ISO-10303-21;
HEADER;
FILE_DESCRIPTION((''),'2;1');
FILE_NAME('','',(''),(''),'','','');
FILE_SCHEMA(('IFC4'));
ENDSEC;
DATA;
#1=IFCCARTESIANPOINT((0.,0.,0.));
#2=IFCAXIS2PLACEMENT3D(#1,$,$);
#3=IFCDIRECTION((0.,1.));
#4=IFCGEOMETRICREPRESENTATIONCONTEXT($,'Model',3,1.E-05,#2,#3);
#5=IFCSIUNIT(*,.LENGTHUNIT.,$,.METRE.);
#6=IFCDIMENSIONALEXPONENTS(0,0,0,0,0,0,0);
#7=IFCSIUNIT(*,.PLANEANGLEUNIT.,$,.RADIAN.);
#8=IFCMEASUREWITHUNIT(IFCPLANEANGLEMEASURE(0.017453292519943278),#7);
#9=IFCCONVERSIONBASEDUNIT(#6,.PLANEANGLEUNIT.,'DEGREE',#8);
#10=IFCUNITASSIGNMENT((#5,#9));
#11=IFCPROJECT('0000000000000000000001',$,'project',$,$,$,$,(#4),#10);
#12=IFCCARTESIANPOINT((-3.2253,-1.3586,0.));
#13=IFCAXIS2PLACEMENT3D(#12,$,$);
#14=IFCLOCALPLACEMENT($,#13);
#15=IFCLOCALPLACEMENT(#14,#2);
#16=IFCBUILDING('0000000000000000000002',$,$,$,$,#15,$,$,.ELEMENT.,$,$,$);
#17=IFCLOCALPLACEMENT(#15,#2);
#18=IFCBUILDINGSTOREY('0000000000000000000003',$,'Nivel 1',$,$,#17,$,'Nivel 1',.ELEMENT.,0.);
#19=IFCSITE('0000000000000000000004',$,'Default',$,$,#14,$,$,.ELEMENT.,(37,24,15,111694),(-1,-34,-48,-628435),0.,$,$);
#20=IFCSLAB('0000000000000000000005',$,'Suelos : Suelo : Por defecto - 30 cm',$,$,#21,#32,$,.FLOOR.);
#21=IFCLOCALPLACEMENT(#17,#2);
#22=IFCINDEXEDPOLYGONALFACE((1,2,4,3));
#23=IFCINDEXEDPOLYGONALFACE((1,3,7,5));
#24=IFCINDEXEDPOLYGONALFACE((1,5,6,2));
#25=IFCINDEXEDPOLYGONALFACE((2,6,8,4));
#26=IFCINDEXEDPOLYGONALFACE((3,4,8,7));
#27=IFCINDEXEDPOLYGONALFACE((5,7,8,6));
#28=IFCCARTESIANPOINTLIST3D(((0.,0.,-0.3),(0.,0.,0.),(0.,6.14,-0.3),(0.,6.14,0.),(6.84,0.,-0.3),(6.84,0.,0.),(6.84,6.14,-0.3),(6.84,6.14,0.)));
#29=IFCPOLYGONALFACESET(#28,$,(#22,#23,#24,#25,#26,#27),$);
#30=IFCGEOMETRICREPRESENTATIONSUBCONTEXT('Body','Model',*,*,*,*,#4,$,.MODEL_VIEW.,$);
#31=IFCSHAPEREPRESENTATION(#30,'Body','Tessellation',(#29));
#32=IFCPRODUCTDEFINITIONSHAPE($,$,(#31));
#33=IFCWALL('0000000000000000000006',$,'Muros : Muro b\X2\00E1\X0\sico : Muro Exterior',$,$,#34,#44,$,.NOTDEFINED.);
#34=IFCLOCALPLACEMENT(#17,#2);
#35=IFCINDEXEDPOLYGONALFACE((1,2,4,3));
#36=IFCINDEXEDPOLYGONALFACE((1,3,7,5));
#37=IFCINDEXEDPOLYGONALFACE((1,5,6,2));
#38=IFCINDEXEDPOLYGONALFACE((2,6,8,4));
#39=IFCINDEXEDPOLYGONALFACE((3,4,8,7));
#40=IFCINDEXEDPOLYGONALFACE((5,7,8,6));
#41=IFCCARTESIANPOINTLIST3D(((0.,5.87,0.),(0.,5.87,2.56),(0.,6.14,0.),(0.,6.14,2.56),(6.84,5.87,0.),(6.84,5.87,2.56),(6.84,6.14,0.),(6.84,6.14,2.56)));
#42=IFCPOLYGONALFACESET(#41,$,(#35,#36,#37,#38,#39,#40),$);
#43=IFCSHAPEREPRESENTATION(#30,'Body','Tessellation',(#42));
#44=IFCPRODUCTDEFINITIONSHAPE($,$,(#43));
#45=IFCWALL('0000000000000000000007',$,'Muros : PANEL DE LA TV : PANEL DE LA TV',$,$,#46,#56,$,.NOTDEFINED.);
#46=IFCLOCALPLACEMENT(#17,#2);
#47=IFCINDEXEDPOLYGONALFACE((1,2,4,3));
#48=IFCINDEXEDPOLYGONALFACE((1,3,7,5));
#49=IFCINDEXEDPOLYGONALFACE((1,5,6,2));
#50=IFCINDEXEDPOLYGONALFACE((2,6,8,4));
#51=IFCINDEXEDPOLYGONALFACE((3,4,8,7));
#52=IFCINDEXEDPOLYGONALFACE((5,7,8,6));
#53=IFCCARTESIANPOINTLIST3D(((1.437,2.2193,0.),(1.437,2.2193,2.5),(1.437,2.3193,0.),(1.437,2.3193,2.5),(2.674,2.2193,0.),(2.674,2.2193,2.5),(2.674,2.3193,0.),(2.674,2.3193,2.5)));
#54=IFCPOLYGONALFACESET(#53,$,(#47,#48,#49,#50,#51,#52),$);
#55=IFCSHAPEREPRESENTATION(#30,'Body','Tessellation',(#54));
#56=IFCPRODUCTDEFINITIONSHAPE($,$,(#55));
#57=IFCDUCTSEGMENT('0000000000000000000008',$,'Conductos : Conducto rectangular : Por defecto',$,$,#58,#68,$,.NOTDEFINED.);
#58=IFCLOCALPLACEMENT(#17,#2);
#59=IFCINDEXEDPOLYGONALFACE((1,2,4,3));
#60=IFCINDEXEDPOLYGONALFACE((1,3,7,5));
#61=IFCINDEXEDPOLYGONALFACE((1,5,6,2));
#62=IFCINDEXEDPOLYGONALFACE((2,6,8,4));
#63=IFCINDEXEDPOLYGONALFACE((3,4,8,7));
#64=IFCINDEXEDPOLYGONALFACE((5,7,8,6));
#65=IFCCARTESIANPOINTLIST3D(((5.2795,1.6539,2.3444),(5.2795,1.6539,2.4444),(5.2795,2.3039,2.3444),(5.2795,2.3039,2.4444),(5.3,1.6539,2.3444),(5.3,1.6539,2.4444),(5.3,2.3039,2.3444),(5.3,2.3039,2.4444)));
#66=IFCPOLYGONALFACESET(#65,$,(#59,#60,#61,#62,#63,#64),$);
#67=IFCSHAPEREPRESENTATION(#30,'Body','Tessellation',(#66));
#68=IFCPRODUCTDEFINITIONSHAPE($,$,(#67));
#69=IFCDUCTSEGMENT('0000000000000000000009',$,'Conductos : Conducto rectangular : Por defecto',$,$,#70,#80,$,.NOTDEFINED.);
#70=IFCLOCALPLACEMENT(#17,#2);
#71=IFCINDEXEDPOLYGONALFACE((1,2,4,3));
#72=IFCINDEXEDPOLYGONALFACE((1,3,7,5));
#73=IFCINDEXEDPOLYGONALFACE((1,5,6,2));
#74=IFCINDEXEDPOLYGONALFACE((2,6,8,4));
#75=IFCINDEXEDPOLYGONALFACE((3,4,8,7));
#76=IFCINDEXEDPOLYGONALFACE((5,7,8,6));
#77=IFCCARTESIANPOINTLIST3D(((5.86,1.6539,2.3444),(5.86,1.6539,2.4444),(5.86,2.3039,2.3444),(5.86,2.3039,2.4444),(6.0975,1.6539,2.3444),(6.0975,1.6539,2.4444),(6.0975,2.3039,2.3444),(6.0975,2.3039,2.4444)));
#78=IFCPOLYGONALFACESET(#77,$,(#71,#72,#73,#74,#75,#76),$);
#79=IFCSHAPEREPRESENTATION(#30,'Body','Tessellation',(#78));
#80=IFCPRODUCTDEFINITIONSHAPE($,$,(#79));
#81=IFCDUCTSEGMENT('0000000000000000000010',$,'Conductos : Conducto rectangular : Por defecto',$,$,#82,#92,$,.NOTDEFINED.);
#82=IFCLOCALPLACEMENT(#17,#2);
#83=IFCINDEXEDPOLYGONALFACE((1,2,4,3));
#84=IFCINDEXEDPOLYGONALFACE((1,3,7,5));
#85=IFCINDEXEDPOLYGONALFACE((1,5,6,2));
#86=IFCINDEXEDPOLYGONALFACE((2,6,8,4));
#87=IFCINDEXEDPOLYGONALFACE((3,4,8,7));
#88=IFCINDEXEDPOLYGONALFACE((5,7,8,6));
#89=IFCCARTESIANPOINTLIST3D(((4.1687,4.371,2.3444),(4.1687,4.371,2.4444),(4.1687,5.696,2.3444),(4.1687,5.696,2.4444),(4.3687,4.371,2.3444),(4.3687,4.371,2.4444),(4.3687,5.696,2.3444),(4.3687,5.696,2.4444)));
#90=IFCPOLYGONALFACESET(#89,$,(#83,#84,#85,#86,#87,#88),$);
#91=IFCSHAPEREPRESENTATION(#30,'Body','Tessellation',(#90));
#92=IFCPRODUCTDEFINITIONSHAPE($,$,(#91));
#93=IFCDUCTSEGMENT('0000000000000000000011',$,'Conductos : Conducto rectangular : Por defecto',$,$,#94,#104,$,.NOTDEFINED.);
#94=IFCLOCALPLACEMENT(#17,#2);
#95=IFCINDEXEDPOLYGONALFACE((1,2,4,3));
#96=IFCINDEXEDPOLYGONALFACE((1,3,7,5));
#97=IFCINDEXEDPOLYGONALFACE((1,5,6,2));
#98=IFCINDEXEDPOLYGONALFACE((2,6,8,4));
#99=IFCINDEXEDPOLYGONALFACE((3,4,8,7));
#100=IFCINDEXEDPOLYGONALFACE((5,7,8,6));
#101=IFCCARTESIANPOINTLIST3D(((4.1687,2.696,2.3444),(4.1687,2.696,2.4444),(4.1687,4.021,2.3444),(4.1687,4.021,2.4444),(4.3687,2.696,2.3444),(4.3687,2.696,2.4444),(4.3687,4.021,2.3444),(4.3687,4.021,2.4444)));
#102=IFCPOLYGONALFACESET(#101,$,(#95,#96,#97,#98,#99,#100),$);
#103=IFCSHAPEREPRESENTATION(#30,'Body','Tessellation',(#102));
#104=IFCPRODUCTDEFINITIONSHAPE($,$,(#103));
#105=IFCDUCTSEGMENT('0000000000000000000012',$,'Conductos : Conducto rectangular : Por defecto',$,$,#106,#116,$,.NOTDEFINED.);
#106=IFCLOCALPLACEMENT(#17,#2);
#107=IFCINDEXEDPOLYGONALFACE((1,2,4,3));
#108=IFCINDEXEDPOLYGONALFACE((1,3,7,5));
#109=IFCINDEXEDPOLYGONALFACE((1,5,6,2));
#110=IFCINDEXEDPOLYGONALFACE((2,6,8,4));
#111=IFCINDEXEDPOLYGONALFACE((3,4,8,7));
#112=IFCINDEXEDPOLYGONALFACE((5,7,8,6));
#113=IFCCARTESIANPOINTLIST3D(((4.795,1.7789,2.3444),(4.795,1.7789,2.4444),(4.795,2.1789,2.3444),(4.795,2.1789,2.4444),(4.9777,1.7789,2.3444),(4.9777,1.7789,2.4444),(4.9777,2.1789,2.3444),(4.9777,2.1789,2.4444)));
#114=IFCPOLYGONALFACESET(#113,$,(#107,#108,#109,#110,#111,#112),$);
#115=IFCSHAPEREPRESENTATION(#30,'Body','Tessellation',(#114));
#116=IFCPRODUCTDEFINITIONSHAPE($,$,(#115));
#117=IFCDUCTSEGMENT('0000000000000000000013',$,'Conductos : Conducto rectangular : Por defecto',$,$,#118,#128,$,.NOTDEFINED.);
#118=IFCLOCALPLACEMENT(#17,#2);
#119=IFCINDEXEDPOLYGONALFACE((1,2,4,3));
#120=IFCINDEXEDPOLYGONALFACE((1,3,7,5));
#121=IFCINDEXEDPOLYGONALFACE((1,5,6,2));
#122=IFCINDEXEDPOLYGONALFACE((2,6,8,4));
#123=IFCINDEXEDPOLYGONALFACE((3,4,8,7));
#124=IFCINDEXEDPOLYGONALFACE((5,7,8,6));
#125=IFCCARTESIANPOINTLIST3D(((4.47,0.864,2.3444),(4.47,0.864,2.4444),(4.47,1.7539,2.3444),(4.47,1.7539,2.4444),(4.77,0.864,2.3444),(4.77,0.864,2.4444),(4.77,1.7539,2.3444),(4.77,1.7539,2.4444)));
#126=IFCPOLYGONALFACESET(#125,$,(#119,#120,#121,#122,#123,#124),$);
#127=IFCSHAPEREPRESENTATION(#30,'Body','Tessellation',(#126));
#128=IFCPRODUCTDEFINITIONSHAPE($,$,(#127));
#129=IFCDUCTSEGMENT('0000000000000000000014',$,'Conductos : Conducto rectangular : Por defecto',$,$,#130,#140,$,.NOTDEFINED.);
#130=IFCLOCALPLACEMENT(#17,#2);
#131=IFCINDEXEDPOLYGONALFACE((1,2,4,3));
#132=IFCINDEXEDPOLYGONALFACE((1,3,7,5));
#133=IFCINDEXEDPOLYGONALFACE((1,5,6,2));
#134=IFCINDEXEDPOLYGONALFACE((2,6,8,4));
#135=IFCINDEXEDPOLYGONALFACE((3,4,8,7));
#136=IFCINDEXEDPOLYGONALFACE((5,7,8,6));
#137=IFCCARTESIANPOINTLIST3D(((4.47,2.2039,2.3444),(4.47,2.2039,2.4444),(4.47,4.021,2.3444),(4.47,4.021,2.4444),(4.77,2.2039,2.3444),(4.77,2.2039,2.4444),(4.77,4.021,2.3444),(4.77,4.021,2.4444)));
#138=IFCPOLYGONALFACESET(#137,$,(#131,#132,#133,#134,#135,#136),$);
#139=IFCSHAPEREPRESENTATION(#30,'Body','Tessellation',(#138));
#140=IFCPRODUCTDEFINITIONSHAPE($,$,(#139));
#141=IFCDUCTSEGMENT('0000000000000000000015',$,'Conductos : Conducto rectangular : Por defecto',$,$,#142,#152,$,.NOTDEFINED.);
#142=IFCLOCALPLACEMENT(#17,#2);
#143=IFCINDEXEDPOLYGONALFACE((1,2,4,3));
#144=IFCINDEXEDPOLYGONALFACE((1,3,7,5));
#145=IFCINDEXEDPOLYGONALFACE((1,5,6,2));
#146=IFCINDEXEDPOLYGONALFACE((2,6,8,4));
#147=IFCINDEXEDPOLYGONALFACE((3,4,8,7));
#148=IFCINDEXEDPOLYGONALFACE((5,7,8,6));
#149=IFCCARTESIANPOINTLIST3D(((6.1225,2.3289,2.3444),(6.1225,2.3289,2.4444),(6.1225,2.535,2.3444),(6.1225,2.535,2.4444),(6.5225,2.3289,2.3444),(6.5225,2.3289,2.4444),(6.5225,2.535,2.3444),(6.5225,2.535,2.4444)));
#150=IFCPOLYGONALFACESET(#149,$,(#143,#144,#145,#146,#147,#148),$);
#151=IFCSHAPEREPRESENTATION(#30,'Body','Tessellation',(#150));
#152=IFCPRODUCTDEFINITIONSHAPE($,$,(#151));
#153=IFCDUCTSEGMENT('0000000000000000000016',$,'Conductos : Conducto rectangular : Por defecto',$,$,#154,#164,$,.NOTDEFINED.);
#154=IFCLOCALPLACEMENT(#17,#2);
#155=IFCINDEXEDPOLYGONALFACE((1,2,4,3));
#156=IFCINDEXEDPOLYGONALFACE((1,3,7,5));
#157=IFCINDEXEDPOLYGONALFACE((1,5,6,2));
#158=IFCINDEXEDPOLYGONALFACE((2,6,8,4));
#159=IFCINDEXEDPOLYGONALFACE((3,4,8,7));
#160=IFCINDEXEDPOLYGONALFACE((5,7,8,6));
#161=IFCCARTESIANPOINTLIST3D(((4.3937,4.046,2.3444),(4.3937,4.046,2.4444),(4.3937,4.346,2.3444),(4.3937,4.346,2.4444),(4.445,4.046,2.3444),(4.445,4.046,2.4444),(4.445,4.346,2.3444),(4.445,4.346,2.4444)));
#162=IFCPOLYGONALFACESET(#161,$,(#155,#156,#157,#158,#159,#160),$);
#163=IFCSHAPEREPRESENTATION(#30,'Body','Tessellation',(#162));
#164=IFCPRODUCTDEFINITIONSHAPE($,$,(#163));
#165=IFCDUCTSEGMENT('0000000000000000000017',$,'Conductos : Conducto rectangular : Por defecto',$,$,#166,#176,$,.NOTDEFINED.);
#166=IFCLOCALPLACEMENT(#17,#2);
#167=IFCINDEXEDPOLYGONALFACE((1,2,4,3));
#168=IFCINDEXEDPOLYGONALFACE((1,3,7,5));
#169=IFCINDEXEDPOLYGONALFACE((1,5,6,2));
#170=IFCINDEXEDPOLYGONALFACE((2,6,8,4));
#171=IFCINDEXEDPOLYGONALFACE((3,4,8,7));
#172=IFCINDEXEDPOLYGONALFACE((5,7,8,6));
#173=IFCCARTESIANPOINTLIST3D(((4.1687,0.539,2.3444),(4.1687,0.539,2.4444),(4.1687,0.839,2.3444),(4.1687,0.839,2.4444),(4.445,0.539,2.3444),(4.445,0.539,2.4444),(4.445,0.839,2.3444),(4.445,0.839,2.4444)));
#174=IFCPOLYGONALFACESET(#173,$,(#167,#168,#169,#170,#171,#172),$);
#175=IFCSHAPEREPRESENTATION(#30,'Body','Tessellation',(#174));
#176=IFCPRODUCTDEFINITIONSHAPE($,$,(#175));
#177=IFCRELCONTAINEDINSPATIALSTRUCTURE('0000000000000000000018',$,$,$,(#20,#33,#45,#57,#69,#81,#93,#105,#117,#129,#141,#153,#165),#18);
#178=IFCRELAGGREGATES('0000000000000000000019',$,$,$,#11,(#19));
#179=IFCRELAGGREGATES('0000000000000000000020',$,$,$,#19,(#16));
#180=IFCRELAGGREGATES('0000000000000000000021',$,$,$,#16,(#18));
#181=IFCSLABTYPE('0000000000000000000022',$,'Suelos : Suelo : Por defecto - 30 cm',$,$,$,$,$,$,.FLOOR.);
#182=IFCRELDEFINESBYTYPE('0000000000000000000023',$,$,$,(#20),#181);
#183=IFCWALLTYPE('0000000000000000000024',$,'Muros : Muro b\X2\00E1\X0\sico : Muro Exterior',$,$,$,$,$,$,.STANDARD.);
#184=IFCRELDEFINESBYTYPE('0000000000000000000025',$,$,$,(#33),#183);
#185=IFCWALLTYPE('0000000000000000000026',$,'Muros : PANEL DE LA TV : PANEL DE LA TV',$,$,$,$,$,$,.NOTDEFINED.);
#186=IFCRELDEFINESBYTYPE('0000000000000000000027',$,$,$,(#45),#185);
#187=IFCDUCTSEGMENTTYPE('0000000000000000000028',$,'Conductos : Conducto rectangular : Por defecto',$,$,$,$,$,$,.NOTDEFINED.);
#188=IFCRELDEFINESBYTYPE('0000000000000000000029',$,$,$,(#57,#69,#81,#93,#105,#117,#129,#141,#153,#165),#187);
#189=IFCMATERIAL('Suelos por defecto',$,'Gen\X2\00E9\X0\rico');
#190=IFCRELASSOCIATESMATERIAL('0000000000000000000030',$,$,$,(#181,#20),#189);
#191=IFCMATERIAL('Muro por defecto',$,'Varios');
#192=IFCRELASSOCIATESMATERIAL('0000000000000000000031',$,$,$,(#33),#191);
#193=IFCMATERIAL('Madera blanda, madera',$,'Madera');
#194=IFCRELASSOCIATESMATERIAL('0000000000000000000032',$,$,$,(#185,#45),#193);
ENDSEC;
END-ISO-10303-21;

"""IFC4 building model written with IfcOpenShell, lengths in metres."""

from ifc_helpers import new_model, entity, si_unit, converted_unit, direction, frame, origin, place, context, subcontext, project, spatial, indexed_curve, outline, extrude, material, type_object, element, save


model = new_model("IFC4")

# Units and contexts
model_context = context("Model", 3, precision=1e-05, world=origin(), true_north=direction((0.0, 1.0)))
body_context = subcontext(model_context, "Body", "Model", "MODEL_VIEW")
ifc_project = project(units=[si_unit("LENGTHUNIT", "METRE"), converted_unit("PLANEANGLEUNIT", "DEGREE", entity("IfcPlaneAngleMeasure", 0.017453292519943278), si_unit("PLANEANGLEUNIT", "RADIAN"), dimensions=[0, 0, 0, 0, 0, 0, 0])], contexts=[model_context])

# Site, building, storey
site_placement = place(None, frame((-3.2253, -1.3586, 0.0)))
site = spatial("IfcSite", under=ifc_project, at=site_placement, Name="Default", CompositionType="ELEMENT", RefLatitude=(37, 24, 15, 111694), RefLongitude=(-1, -34, -48, -628435), RefElevation=0.0)
building_placement = place(site_placement, origin())
building = spatial("IfcBuilding", under=site, at=building_placement, CompositionType="ELEMENT")
storey_placement = place(building_placement, origin())
storey = spatial("IfcBuildingStorey", under=building, at=storey_placement, Name="Nivel 1", LongName="Nivel 1", CompositionType="ELEMENT", Elevation=0.0)

# Slab
ifc_material_1 = material(Name="Suelos por defecto", Category="Genérico")
slab_type = type_object("IfcSlabType", Name="Suelos : Suelo : Por defecto - 30 cm", PredefinedType="FLOOR", material=ifc_material_1)
slab_placement = place(storey_placement, origin())
element("IfcSlab", 1, at=slab_placement, inside=storey, type_object=slab_type, material=ifc_material_1, Name="Suelos : Suelo : Por defecto - 30 cm", PredefinedType="FLOOR", context=body_context, shape_type="SweptSolid", body=[
    extrude(outline(indexed_curve([(-3.07, -3.42), (3.07, -3.42), (3.07, 3.42), (-3.07, 3.42), (-3.07, -3.42)], self_intersect=False)), frame((3.42, 3.07, 0.0), z_axis=(0.0, 0.0, -1.0), x_axis=(0.0, 1.0, 0.0)), (0.0, 0.0, 1.0), 0.3),
])

# Walls
ifc_material_2 = material(Name="Muro por defecto", Category="Varios")
wall_type_1 = type_object("IfcWallType", Name="Muros : Muro básico : Muro Exterior", PredefinedType="STANDARD")
wall_1_placement = place(storey_placement, frame((0.0, 6.005, 0.0)))
element("IfcWall", 2, at=wall_1_placement, inside=storey, type_object=wall_type_1, material=ifc_material_2, Name="Muros : Muro básico : Muro Exterior", PredefinedType="NOTDEFINED", context=body_context, shape_type="SweptSolid", body=[
    extrude(outline(indexed_curve([(6.84, 0.135), (0.0, 0.135), (0.0, -0.135), (6.84, -0.135), (6.84, 0.135)], self_intersect=False)), origin(), (0.0, 0.0, 1.0), 2.56),
])
ifc_material_3 = material(Name="Madera blanda, madera", Category="Madera")
wall_type_2 = type_object("IfcWallType", Name="Muros : PANEL DE LA TV : PANEL DE LA TV", PredefinedType="NOTDEFINED", material=ifc_material_3)
wall_2_placement = place(storey_placement, frame((1.437, 2.2193, 0.0)))
element("IfcWall", 3, at=wall_2_placement, inside=storey, type_object=wall_type_2, material=ifc_material_3, Name="Muros : PANEL DE LA TV : PANEL DE LA TV", PredefinedType="NOTDEFINED", context=body_context, shape_type="SweptSolid", body=[
    extrude(outline(indexed_curve([(-0.05, -0.6185), (0.05, -0.6185), (0.05, 0.6185), (-0.05, 0.6185), (-0.05, -0.6185)], self_intersect=False)), frame((0.6185, 0.05, 0.0), z_axis=(0.0, 0.0, 1.0), x_axis=(0.0, 1.0, 0.0)), (0.0, 0.0, 1.0), 2.5),
])

# Duct segments
duct_segment_type = type_object("IfcDuctSegmentType", Name="Conductos : Conducto rectangular : Por defecto", PredefinedType="NOTDEFINED")
duct_segment_1_placement = place(storey_placement, origin())
element("IfcDuctSegment", 4, at=duct_segment_1_placement, inside=storey, type_object=duct_segment_type, Name="Conductos : Conducto rectangular : Por defecto", PredefinedType="NOTDEFINED", context=body_context, shape_type="SweptSolid", body=[
    extrude(outline(indexed_curve([(-0.0102, -0.325), (0.0102, -0.325), (0.0102, 0.325), (-0.0102, 0.325), (-0.0102, -0.325)], self_intersect=False)), frame((5.2898, 1.9789, 2.3444)), (0.0, 0.0, 1.0), 0.1),
])
duct_segment_2_placement = place(storey_placement, origin())
element("IfcDuctSegment", 5, at=duct_segment_2_placement, inside=storey, type_object=duct_segment_type, Name="Conductos : Conducto rectangular : Por defecto", PredefinedType="NOTDEFINED", context=body_context, shape_type="SweptSolid", body=[
    extrude(outline(indexed_curve([(-0.1187, -0.325), (0.1187, -0.325), (0.1187, 0.325), (-0.1187, 0.325), (-0.1187, -0.325)], self_intersect=False)), frame((5.9787, 1.9789, 2.3444), z_axis=(0.0, 0.0, 1.0), x_axis=(-1.0, 0.0, 0.0)), (0.0, 0.0, 1.0), 0.1),
])
duct_segment_3_placement = place(storey_placement, origin())
element("IfcDuctSegment", 6, at=duct_segment_3_placement, inside=storey, type_object=duct_segment_type, Name="Conductos : Conducto rectangular : Por defecto", PredefinedType="NOTDEFINED", context=body_context, shape_type="SweptSolid", body=[
    extrude(outline(indexed_curve([(-0.6625, -0.1), (0.6625, -0.1), (0.6625, 0.1), (-0.6625, 0.1), (-0.6625, -0.1)], self_intersect=False)), frame((4.2687, 5.0335, 2.3444), z_axis=(0.0, 0.0, 1.0), x_axis=(0.0, 1.0, 0.0)), (0.0, 0.0, 1.0), 0.1),
])
duct_segment_4_placement = place(storey_placement, origin())
element("IfcDuctSegment", 7, at=duct_segment_4_placement, inside=storey, type_object=duct_segment_type, Name="Conductos : Conducto rectangular : Por defecto", PredefinedType="NOTDEFINED", context=body_context, shape_type="SweptSolid", body=[
    extrude(outline(indexed_curve([(-0.6625, -0.1), (0.6625, -0.1), (0.6625, 0.1), (-0.6625, 0.1), (-0.6625, -0.1)], self_intersect=False)), frame((4.2687, 3.3585, 2.3444), z_axis=(0.0, 0.0, 1.0), x_axis=(0.0, -1.0, 0.0)), (0.0, 0.0, 1.0), 0.1),
])
duct_segment_5_placement = place(storey_placement, origin())
element("IfcDuctSegment", 8, at=duct_segment_5_placement, inside=storey, type_object=duct_segment_type, Name="Conductos : Conducto rectangular : Por defecto", PredefinedType="NOTDEFINED", context=body_context, shape_type="SweptSolid", body=[
    extrude(outline(indexed_curve([(-0.0914, -0.2), (0.0914, -0.2), (0.0914, 0.2), (-0.0914, 0.2), (-0.0914, -0.2)], self_intersect=False)), frame((4.8864, 1.9789, 2.3444), z_axis=(0.0, 0.0, 1.0), x_axis=(-1.0, 0.0, 0.0)), (0.0, 0.0, 1.0), 0.1),
])
duct_segment_6_placement = place(storey_placement, origin())
element("IfcDuctSegment", 9, at=duct_segment_6_placement, inside=storey, type_object=duct_segment_type, Name="Conductos : Conducto rectangular : Por defecto", PredefinedType="NOTDEFINED", context=body_context, shape_type="SweptSolid", body=[
    extrude(outline(indexed_curve([(-0.445, -0.15), (0.445, -0.15), (0.445, 0.15), (-0.445, 0.15), (-0.445, -0.15)], self_intersect=False)), frame((4.62, 1.309, 2.3444), z_axis=(0.0, 0.0, 1.0), x_axis=(0.0, -1.0, 0.0)), (0.0, 0.0, 1.0), 0.1),
])
duct_segment_7_placement = place(storey_placement, origin())
element("IfcDuctSegment", 10, at=duct_segment_7_placement, inside=storey, type_object=duct_segment_type, Name="Conductos : Conducto rectangular : Por defecto", PredefinedType="NOTDEFINED", context=body_context, shape_type="SweptSolid", body=[
    extrude(outline(indexed_curve([(-0.9085, -0.15), (0.9085, -0.15), (0.9085, 0.15), (-0.9085, 0.15), (-0.9085, -0.15)], self_intersect=False)), frame((4.62, 3.1125, 2.3444), z_axis=(0.0, 0.0, 1.0), x_axis=(0.0, 1.0, 0.0)), (0.0, 0.0, 1.0), 0.1),
])
duct_segment_8_placement = place(storey_placement, origin())
element("IfcDuctSegment", 11, at=duct_segment_8_placement, inside=storey, type_object=duct_segment_type, Name="Conductos : Conducto rectangular : Por defecto", PredefinedType="NOTDEFINED", context=body_context, shape_type="SweptSolid", body=[
    extrude(outline(indexed_curve([(-0.103, -0.2), (0.103, -0.2), (0.103, 0.2), (-0.103, 0.2), (-0.103, -0.2)], self_intersect=False)), frame((6.3225, 2.432, 2.3444), z_axis=(0.0, 0.0, 1.0), x_axis=(0.0, 1.0, 0.0)), (0.0, 0.0, 1.0), 0.1),
])
duct_segment_9_placement = place(storey_placement, origin())
element("IfcDuctSegment", 12, at=duct_segment_9_placement, inside=storey, type_object=duct_segment_type, Name="Conductos : Conducto rectangular : Por defecto", PredefinedType="NOTDEFINED", context=body_context, shape_type="SweptSolid", body=[
    extrude(outline(indexed_curve([(-0.0256, -0.15), (0.0256, -0.15), (0.0256, 0.15), (-0.0256, 0.15), (-0.0256, -0.15)], self_intersect=False)), frame((4.4194, 4.196, 2.3444)), (0.0, 0.0, 1.0), 0.1),
])
duct_segment_10_placement = place(storey_placement, origin())
element("IfcDuctSegment", 13, at=duct_segment_10_placement, inside=storey, type_object=duct_segment_type, Name="Conductos : Conducto rectangular : Por defecto", PredefinedType="NOTDEFINED", context=body_context, shape_type="SweptSolid", body=[
    extrude(outline(indexed_curve([(-0.1382, -0.15), (0.1382, -0.15), (0.1382, 0.15), (-0.1382, 0.15), (-0.1382, -0.15)], self_intersect=False)), frame((4.3069, 0.689, 2.3444), z_axis=(0.0, 0.0, 1.0), x_axis=(-1.0, 0.0, 0.0)), (0.0, 0.0, 1.0), 0.1),
])

save(model, "model.ifc")
